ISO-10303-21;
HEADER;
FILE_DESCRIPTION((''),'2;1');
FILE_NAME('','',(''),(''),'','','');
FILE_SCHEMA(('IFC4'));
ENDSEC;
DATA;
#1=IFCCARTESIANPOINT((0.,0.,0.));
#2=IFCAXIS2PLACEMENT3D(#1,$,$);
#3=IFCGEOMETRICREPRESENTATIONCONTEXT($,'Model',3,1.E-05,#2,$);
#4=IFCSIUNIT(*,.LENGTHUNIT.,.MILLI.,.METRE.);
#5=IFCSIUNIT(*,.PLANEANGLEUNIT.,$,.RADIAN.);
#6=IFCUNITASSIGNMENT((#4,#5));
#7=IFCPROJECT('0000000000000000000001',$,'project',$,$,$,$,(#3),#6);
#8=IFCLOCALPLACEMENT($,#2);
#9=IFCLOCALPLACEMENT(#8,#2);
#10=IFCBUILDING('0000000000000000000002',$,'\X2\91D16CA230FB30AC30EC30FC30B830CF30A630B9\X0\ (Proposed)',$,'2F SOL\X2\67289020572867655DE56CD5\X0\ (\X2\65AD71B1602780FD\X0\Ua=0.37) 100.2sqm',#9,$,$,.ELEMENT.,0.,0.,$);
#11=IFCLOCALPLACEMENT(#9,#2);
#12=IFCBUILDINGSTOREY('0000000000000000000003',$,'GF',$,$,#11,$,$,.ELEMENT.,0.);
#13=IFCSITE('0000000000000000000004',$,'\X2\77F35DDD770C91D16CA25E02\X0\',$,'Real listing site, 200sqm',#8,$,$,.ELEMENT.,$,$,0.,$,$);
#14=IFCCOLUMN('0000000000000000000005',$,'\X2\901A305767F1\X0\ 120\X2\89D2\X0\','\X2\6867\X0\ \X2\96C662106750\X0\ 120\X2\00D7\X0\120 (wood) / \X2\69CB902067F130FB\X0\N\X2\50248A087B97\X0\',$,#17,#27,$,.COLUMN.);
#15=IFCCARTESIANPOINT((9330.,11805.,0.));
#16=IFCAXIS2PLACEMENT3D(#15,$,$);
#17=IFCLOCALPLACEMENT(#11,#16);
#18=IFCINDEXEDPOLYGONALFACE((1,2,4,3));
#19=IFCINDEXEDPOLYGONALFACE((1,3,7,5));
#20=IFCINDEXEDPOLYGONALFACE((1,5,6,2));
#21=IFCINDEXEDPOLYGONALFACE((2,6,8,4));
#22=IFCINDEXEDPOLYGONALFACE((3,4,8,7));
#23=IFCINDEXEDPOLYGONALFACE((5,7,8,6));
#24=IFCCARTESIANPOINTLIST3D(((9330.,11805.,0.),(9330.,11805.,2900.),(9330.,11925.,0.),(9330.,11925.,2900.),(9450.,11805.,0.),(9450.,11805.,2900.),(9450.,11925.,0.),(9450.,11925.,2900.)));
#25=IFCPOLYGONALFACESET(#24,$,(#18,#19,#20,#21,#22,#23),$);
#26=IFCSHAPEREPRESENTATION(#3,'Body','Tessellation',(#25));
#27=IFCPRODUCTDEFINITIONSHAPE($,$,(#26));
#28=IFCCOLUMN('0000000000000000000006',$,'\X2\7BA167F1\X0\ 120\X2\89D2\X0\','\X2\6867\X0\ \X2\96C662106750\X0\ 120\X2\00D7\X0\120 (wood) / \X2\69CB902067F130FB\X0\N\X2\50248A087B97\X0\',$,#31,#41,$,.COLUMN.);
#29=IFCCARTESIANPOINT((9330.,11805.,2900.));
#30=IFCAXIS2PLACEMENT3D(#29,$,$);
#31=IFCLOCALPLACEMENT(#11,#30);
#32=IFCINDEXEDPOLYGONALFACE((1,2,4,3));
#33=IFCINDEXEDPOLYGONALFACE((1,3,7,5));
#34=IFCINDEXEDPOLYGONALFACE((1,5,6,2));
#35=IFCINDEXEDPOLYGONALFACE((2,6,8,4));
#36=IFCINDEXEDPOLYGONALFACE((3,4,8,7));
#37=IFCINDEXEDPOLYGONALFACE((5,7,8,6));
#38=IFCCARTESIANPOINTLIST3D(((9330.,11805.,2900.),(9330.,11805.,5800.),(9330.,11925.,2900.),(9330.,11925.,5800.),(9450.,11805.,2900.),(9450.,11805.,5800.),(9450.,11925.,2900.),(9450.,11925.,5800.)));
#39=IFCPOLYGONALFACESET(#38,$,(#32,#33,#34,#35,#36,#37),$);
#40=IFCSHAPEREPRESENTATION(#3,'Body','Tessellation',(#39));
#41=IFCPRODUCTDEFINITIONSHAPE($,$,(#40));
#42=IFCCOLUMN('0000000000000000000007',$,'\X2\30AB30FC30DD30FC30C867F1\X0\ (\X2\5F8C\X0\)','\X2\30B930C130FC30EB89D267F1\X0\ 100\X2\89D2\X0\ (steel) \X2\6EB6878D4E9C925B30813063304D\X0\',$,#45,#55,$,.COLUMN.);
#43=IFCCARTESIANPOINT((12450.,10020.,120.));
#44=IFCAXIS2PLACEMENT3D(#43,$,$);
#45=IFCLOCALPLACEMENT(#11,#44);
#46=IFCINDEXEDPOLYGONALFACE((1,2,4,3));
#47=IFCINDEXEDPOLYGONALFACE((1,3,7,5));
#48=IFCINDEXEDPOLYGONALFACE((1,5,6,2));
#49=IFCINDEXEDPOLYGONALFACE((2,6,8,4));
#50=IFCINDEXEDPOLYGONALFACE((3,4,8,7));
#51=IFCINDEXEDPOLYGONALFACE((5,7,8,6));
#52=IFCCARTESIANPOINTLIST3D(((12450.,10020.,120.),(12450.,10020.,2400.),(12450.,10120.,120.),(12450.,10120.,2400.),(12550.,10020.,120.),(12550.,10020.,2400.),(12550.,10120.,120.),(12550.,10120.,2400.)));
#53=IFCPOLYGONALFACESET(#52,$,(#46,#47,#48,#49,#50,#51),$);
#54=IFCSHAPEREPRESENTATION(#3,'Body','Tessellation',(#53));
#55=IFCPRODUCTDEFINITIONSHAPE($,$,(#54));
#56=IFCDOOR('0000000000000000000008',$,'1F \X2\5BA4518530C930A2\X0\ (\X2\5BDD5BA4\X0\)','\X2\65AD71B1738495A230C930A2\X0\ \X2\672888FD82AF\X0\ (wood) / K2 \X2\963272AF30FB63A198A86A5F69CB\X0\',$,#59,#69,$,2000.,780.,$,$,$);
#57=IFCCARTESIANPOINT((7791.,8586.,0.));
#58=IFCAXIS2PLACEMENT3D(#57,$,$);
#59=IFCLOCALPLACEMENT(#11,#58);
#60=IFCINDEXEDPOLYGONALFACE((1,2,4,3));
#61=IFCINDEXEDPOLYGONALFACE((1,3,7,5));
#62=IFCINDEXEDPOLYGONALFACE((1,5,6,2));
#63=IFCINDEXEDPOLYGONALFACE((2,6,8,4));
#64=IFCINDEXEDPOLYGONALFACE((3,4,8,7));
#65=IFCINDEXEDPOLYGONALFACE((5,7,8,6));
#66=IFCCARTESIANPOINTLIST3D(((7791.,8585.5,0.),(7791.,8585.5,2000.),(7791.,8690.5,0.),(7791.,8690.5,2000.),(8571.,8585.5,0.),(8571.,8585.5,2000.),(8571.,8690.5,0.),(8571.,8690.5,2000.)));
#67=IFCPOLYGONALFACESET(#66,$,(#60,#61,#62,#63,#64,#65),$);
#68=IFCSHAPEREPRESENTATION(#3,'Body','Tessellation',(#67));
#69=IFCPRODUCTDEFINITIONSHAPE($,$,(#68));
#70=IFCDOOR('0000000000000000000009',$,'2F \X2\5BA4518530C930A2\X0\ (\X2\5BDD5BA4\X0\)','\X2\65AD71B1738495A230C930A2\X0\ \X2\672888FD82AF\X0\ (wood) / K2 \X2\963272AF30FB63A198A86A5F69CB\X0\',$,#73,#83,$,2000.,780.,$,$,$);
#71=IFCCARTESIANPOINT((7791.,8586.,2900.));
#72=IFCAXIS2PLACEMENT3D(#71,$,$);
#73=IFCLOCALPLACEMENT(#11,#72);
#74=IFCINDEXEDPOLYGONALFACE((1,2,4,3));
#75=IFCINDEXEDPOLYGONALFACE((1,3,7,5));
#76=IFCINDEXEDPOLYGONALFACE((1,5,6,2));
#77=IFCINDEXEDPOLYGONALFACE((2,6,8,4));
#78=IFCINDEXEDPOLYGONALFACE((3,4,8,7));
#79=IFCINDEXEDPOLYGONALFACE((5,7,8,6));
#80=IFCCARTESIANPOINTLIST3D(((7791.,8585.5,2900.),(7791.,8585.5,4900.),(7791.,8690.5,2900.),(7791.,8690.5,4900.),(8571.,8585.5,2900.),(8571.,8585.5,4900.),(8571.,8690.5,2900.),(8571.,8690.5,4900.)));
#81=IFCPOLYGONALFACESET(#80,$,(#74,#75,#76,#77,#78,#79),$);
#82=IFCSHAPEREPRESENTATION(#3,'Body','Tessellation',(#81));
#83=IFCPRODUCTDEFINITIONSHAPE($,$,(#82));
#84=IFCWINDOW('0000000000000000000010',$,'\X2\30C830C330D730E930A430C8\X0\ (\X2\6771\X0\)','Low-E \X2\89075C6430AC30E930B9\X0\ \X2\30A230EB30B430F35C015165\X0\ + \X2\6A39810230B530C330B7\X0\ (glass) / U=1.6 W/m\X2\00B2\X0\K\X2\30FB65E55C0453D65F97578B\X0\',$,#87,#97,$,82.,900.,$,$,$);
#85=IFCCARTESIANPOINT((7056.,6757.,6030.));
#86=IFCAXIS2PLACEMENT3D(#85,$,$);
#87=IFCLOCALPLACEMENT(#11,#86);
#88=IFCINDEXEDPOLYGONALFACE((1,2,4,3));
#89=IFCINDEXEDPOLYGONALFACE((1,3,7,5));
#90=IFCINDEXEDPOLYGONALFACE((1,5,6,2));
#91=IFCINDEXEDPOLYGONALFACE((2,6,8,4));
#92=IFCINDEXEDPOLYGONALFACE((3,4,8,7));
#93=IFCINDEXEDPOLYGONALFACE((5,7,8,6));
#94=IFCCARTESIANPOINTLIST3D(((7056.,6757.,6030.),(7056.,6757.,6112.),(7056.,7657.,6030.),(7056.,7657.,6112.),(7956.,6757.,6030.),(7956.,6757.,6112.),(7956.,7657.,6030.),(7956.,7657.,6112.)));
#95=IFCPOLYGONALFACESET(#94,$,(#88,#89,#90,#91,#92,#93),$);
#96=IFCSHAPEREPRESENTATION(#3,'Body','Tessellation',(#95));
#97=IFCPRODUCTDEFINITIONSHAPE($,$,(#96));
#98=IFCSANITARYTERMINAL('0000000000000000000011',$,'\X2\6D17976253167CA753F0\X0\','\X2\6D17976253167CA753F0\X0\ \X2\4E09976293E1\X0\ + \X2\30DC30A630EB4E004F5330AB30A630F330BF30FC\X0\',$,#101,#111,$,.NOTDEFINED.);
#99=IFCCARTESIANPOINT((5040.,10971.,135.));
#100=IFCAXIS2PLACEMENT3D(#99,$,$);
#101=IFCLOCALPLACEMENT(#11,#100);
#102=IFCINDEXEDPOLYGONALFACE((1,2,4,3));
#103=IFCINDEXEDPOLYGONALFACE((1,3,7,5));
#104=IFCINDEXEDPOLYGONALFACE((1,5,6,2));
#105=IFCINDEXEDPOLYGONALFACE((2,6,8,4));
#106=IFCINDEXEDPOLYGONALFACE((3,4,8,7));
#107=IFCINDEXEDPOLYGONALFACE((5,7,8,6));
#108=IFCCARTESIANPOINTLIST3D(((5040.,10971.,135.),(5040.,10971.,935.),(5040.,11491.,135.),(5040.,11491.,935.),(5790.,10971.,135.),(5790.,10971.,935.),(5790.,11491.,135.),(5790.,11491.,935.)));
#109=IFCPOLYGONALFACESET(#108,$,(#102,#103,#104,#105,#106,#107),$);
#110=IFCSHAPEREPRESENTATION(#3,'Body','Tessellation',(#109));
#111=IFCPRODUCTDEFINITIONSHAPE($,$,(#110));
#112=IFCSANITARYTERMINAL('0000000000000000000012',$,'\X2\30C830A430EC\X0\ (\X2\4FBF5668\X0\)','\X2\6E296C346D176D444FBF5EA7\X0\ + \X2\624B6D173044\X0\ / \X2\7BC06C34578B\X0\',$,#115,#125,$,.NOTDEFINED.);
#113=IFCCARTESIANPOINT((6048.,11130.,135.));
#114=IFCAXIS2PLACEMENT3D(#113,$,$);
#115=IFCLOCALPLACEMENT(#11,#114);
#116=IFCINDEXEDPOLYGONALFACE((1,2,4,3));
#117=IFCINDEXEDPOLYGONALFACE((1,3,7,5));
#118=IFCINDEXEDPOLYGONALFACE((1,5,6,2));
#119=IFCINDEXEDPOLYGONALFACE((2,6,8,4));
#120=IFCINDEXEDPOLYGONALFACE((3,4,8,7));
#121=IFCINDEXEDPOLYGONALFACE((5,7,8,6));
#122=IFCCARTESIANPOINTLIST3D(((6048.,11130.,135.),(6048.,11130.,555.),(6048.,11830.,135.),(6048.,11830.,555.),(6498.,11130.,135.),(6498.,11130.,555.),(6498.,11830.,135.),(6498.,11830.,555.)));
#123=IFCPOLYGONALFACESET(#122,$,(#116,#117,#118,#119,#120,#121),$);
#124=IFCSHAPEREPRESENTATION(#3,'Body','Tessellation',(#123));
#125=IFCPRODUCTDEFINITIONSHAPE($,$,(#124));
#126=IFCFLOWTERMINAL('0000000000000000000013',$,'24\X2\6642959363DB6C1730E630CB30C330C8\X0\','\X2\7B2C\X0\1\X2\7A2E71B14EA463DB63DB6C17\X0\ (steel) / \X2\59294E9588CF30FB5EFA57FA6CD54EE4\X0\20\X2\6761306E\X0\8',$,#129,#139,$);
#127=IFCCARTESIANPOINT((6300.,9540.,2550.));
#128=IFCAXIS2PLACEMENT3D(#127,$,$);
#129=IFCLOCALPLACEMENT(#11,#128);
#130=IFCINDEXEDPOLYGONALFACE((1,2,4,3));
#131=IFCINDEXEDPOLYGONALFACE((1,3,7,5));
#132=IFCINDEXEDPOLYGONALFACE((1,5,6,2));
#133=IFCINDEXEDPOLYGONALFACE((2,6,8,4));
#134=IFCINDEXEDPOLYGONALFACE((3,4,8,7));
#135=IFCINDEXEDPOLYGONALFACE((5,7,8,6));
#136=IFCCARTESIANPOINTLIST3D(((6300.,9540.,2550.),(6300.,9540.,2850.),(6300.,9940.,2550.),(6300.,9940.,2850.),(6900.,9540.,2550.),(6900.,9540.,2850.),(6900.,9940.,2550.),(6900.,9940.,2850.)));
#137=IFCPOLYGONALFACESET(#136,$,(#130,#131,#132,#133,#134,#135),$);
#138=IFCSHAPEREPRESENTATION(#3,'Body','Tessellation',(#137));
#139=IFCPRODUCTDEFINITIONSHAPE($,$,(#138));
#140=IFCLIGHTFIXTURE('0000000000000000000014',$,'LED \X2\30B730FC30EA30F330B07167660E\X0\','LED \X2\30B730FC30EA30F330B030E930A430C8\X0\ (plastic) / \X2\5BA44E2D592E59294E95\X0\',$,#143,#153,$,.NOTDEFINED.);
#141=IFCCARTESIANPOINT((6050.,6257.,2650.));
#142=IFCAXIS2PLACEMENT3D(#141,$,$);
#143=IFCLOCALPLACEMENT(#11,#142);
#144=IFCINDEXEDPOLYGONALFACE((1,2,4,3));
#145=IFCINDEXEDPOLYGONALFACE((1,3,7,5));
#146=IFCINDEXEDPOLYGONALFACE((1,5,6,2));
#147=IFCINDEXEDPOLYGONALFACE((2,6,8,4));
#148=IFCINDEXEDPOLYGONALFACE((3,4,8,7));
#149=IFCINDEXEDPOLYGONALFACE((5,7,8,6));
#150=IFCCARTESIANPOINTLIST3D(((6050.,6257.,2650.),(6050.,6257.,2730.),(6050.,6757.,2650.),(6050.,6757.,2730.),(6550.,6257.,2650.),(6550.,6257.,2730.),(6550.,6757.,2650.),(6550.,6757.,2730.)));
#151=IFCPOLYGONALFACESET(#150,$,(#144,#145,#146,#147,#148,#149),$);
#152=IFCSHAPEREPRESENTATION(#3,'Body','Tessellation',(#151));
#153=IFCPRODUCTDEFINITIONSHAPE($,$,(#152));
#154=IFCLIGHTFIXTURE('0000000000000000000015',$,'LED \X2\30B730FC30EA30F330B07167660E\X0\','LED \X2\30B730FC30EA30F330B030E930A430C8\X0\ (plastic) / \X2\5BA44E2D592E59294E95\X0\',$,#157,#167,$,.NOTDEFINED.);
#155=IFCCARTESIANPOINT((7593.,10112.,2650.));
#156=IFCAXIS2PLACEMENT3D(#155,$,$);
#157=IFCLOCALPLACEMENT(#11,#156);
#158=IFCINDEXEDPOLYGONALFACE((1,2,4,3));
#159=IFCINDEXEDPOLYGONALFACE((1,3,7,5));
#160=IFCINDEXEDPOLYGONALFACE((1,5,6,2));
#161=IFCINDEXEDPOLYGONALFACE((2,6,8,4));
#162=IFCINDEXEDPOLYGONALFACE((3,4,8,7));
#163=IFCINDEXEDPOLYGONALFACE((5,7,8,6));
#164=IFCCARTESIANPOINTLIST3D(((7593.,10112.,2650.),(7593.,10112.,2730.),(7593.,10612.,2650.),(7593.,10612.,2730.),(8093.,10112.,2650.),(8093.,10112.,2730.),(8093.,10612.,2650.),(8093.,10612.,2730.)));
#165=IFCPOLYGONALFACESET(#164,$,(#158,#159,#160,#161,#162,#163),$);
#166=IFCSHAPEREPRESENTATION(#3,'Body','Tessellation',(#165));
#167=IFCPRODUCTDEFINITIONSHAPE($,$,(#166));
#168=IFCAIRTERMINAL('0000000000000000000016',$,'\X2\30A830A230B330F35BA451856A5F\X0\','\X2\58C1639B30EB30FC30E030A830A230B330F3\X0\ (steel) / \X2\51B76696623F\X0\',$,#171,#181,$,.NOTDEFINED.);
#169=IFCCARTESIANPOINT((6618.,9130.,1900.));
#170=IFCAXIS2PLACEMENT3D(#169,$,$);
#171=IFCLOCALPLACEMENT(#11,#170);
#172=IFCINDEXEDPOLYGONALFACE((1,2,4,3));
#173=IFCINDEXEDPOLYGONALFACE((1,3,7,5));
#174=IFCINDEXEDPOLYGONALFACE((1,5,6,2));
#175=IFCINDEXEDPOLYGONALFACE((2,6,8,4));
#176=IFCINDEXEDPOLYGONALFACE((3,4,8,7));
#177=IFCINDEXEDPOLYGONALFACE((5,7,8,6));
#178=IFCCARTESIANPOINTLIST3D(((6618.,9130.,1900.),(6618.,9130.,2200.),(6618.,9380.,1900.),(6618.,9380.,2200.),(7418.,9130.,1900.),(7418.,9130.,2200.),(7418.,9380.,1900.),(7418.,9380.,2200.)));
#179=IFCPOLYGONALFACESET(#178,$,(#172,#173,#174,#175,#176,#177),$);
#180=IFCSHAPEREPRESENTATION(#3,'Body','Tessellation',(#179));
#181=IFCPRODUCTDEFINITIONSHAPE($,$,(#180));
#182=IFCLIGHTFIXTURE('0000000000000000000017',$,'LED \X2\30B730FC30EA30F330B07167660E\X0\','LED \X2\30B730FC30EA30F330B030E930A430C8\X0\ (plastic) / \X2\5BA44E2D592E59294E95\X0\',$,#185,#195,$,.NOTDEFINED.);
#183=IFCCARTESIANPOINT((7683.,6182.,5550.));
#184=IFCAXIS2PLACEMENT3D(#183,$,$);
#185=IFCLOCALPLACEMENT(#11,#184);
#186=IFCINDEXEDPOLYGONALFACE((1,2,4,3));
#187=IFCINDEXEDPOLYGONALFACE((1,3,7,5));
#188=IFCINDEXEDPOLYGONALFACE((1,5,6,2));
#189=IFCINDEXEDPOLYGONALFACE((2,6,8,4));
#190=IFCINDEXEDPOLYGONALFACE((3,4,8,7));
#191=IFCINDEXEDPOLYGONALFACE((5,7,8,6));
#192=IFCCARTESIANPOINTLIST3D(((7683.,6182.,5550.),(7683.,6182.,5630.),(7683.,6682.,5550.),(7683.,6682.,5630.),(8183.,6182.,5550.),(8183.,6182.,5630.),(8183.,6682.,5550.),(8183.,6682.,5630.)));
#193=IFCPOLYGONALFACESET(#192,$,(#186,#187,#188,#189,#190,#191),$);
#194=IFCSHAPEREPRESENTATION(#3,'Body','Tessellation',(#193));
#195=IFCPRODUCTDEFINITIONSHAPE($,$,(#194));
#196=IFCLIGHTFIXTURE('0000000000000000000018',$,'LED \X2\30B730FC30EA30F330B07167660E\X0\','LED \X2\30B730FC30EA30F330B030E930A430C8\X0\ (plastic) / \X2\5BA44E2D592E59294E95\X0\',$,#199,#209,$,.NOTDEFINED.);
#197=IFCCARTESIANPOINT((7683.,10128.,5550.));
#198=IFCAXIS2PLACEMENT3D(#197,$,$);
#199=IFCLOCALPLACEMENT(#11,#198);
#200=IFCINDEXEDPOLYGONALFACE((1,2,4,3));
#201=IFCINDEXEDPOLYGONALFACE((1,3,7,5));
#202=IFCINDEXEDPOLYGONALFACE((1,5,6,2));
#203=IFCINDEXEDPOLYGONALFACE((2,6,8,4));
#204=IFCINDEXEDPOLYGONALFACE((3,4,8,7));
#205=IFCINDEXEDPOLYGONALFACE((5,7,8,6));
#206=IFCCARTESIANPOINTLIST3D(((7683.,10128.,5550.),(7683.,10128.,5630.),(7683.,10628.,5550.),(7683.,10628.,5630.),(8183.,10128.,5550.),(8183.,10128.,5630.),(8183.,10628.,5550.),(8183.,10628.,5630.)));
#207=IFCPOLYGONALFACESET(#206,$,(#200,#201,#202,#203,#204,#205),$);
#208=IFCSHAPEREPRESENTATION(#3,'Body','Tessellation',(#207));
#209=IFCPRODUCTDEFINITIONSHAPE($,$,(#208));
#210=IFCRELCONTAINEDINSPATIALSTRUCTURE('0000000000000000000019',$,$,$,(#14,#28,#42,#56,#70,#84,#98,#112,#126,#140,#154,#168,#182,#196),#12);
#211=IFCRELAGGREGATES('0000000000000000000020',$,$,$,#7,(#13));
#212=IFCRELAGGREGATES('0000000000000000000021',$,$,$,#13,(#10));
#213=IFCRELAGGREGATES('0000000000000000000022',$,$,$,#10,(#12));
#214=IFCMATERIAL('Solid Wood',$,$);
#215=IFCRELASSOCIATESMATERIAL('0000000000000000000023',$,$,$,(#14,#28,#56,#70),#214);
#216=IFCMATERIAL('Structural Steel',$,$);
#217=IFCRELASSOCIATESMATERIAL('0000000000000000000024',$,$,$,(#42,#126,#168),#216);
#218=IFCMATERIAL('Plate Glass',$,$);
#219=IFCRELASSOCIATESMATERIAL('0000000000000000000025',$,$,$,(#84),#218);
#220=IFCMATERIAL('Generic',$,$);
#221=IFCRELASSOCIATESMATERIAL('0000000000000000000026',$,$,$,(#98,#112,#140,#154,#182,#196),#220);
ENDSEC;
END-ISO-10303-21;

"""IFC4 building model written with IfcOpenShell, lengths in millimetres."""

from ifc_helpers import new_model, si_unit, frame, frame_2d, origin, place, context, project, spatial, rectangle, extrude, material, element, save


model = new_model("IFC4")

# Units and contexts
model_context = context("Model", 3, precision=1e-05, world=origin())
ifc_project = project(units=[si_unit("LENGTHUNIT", "METRE", prefix="MILLI"), si_unit("PLANEANGLEUNIT", "RADIAN")], contexts=[model_context])

# Site, building, storey
site_placement = place(None, origin())
site = spatial("IfcSite", under=ifc_project, at=site_placement, Name="石川県金沢市", ObjectType="Real listing site, 200sqm", CompositionType="ELEMENT", RefElevation=0.0)
building_placement = place(site_placement, origin())
building = spatial("IfcBuilding", under=site, at=building_placement, Name="金沢・ガレージハウス (Proposed)", ObjectType="2F SOL木造在来工法 (断熱性能Ua=0.37) 100.2sqm", CompositionType="ELEMENT", ElevationOfRefHeight=0.0, ElevationOfTerrain=0.0)
storey_placement = place(building_placement, origin())
storey = spatial("IfcBuildingStorey", under=building, at=storey_placement, Name="GF", CompositionType="ELEMENT", Elevation=0.0)

# Columns
ifc_material_1 = material(Name="Solid Wood")
column_1_placement = place(storey_placement, frame((9330.0, 11805.0, 0.0)))
element("IfcColumn", 1, at=column_1_placement, inside=storey, material=ifc_material_1, Name="通し柱 120角", Description="桧 集成材 120×120 (wood) / 構造柱・N値計算", PredefinedType="COLUMN", context=model_context, shape_type="SweptSolid", body=[
    extrude(rectangle(XDim=120.0, YDim=120.0, at=frame_2d((60.0, 60.0))), frame((9330.0, 11805.0, 0.0)), (0.0, 0.0, 1.0), 2900.0),
])
column_2_placement = place(storey_placement, frame((9330.0, 11805.0, 2900.0)))
element("IfcColumn", 2, at=column_2_placement, inside=storey, material=ifc_material_1, Name="管柱 120角", Description="桧 集成材 120×120 (wood) / 構造柱・N値計算", PredefinedType="COLUMN", context=model_context, shape_type="SweptSolid", body=[
    extrude(rectangle(XDim=120.0, YDim=120.0, at=frame_2d((60.0, 60.0))), frame((9330.0, 11805.0, 2900.0)), (0.0, 0.0, 1.0), 2900.0),
])
ifc_material_2 = material(Name="Structural Steel")
column_3_placement = place(storey_placement, frame((12450.0, 10020.0, 120.0)))
element("IfcColumn", 3, at=column_3_placement, inside=storey, material=ifc_material_2, Name="カーポート柱 (後)", Description="スチール角柱 100角 (steel) 溶融亜鉛めっき", PredefinedType="COLUMN", context=model_context, shape_type="SweptSolid", body=[
    extrude(rectangle(XDim=100.0, YDim=100.0, at=frame_2d((50.0, 50.0))), frame((12450.0, 10020.0, 120.0)), (0.0, 0.0, 1.0), 2280.0),
])

# Door
door_1_placement = place(storey_placement, frame((7791.0, 8586.0, 0.0)))
element("IfcDoor", 4, at=door_1_placement, inside=storey, material=ifc_material_1, Name="1F 室内ドア (寝室)", Description="断熱玄関ドア 木製芯 (wood) / K2 防犯・採風機構", OverallHeight=2000.0, OverallWidth=780.0, context=model_context, shape_type="SweptSolid", body=[
    extrude(rectangle(XDim=780.0, YDim=105.0, at=frame_2d((390.0, 52.0))), frame((7791.0, 8586.0, 0.0)), (0.0, 0.0, 1.0), 2000.0),
])

# Door
door_2_placement = place(storey_placement, frame((7791.0, 8586.0, 2900.0)))
element("IfcDoor", 5, at=door_2_placement, inside=storey, material=ifc_material_1, Name="2F 室内ドア (寝室)", Description="断熱玄関ドア 木製芯 (wood) / K2 防犯・採風機構", OverallHeight=2000.0, OverallWidth=780.0, context=model_context, shape_type="SweptSolid", body=[
    extrude(rectangle(XDim=780.0, YDim=105.0, at=frame_2d((390.0, 52.0))), frame((7791.0, 8586.0, 2900.0)), (0.0, 0.0, 1.0), 2000.0),
])

# Window
ifc_material_3 = material(Name="Plate Glass")
window_placement = place(storey_placement, frame((7056.0, 6757.0, 6030.0)))
element("IfcWindow", 6, at=window_placement, inside=storey, material=ifc_material_3, Name="トップライト (東)", Description="Low-E 複層ガラス アルゴン封入 + 樹脂サッシ (glass) / U=1.6 W/m²K・日射取得型", OverallHeight=82.0, OverallWidth=900.0, context=model_context, shape_type="SweptSolid", body=[
    extrude(rectangle(XDim=900.0, YDim=900.0, at=frame_2d((450.0, 450.0))), frame((7056.0, 6757.0, 6030.0)), (0.0, 0.0, 1.0), 82.0),
])

# Sanitary terminals
ifc_material_4 = material(Name="Generic")
sanitary_terminal_1_placement = place(storey_placement, frame((5040.0, 10971.0, 135.0)))
element("IfcSanitaryTerminal", 7, at=sanitary_terminal_1_placement, inside=storey, material=ifc_material_4, Name="洗面化粧台", Description="洗面化粧台 三面鏡 + ボウル一体カウンター", PredefinedType="NOTDEFINED", context=model_context, shape_type="SweptSolid", body=[
    extrude(rectangle(XDim=750.0, YDim=520.0, at=frame_2d((375.0, 260.0))), frame((5040.0, 10971.0, 135.0)), (0.0, 0.0, 1.0), 800.0),
])
sanitary_terminal_2_placement = place(storey_placement, frame((6048.0, 11130.0, 135.0)))
element("IfcSanitaryTerminal", 8, at=sanitary_terminal_2_placement, inside=storey, material=ifc_material_4, Name="トイレ (便器)", Description="温水洗浄便座 + 手洗い / 節水型", PredefinedType="NOTDEFINED", context=model_context, shape_type="SweptSolid", body=[
    extrude(rectangle(XDim=450.0, YDim=700.0, at=frame_2d((225.0, 350.0))), frame((6048.0, 11130.0, 135.0)), (0.0, 0.0, 1.0), 420.0),
])

# Flow terminal
flow_terminal_placement = place(storey_placement, frame((6300.0, 9540.0, 2550.0)))
element("IfcFlowTerminal", 9, at=flow_terminal_placement, inside=storey, material=ifc_material_2, Name="24時間換気ユニット", Description="第1種熱交換換気 (steel) / 天井裏・建基法令20条の8", context=model_context, shape_type="SweptSolid", body=[
    extrude(rectangle(XDim=600.0, YDim=400.0, at=frame_2d((300.0, 200.0))), frame((6300.0, 9540.0, 2550.0)), (0.0, 0.0, 1.0), 300.0),
])

# Light fixtures
light_fixture_1_placement = place(storey_placement, frame((6050.0, 6257.0, 2650.0)))
element("IfcLightFixture", 10, at=light_fixture_1_placement, inside=storey, material=ifc_material_4, Name="LED シーリング照明", Description="LED シーリングライト (plastic) / 室中央天井", PredefinedType="NOTDEFINED", context=model_context, shape_type="SweptSolid", body=[
    extrude(rectangle(XDim=500.0, YDim=500.0, at=frame_2d((250.0, 250.0))), frame((6050.0, 6257.0, 2650.0)), (0.0, 0.0, 1.0), 80.0),
])
light_fixture_2_placement = place(storey_placement, frame((7593.0, 10112.0, 2650.0)))
element("IfcLightFixture", 11, at=light_fixture_2_placement, inside=storey, material=ifc_material_4, Name="LED シーリング照明", Description="LED シーリングライト (plastic) / 室中央天井", PredefinedType="NOTDEFINED", context=model_context, shape_type="SweptSolid", body=[
    extrude(rectangle(XDim=500.0, YDim=500.0, at=frame_2d((250.0, 250.0))), frame((7593.0, 10112.0, 2650.0)), (0.0, 0.0, 1.0), 80.0),
])

# Air terminal
air_terminal_placement = place(storey_placement, frame((6618.0, 9130.0, 1900.0)))
element("IfcAirTerminal", 12, at=air_terminal_placement, inside=storey, material=ifc_material_2, Name="エアコン室内機", Description="壁掛ルームエアコン (steel) / 冷暖房", PredefinedType="NOTDEFINED", context=model_context, shape_type="SweptSolid", body=[
    extrude(rectangle(XDim=800.0, YDim=250.0, at=frame_2d((400.0, 125.0))), frame((6618.0, 9130.0, 1900.0)), (0.0, 0.0, 1.0), 300.0),
])

# Light fixtures
light_fixture_3_placement = place(storey_placement, frame((7683.0, 6182.0, 5550.0)))
element("IfcLightFixture", 13, at=light_fixture_3_placement, inside=storey, material=ifc_material_4, Name="LED シーリング照明", Description="LED シーリングライト (plastic) / 室中央天井", PredefinedType="NOTDEFINED", context=model_context, shape_type="SweptSolid", body=[
    extrude(rectangle(XDim=500.0, YDim=500.0, at=frame_2d((250.0, 250.0))), frame((7683.0, 6182.0, 5550.0)), (0.0, 0.0, 1.0), 80.0),
])
light_fixture_4_placement = place(storey_placement, frame((7683.0, 10128.0, 5550.0)))
element("IfcLightFixture", 14, at=light_fixture_4_placement, inside=storey, material=ifc_material_4, Name="LED シーリング照明", Description="LED シーリングライト (plastic) / 室中央天井", PredefinedType="NOTDEFINED", context=model_context, shape_type="SweptSolid", body=[
    extrude(rectangle(XDim=500.0, YDim=500.0, at=frame_2d((250.0, 250.0))), frame((7683.0, 10128.0, 5550.0)), (0.0, 0.0, 1.0), 80.0),
])

save(model, "model.ifc")
